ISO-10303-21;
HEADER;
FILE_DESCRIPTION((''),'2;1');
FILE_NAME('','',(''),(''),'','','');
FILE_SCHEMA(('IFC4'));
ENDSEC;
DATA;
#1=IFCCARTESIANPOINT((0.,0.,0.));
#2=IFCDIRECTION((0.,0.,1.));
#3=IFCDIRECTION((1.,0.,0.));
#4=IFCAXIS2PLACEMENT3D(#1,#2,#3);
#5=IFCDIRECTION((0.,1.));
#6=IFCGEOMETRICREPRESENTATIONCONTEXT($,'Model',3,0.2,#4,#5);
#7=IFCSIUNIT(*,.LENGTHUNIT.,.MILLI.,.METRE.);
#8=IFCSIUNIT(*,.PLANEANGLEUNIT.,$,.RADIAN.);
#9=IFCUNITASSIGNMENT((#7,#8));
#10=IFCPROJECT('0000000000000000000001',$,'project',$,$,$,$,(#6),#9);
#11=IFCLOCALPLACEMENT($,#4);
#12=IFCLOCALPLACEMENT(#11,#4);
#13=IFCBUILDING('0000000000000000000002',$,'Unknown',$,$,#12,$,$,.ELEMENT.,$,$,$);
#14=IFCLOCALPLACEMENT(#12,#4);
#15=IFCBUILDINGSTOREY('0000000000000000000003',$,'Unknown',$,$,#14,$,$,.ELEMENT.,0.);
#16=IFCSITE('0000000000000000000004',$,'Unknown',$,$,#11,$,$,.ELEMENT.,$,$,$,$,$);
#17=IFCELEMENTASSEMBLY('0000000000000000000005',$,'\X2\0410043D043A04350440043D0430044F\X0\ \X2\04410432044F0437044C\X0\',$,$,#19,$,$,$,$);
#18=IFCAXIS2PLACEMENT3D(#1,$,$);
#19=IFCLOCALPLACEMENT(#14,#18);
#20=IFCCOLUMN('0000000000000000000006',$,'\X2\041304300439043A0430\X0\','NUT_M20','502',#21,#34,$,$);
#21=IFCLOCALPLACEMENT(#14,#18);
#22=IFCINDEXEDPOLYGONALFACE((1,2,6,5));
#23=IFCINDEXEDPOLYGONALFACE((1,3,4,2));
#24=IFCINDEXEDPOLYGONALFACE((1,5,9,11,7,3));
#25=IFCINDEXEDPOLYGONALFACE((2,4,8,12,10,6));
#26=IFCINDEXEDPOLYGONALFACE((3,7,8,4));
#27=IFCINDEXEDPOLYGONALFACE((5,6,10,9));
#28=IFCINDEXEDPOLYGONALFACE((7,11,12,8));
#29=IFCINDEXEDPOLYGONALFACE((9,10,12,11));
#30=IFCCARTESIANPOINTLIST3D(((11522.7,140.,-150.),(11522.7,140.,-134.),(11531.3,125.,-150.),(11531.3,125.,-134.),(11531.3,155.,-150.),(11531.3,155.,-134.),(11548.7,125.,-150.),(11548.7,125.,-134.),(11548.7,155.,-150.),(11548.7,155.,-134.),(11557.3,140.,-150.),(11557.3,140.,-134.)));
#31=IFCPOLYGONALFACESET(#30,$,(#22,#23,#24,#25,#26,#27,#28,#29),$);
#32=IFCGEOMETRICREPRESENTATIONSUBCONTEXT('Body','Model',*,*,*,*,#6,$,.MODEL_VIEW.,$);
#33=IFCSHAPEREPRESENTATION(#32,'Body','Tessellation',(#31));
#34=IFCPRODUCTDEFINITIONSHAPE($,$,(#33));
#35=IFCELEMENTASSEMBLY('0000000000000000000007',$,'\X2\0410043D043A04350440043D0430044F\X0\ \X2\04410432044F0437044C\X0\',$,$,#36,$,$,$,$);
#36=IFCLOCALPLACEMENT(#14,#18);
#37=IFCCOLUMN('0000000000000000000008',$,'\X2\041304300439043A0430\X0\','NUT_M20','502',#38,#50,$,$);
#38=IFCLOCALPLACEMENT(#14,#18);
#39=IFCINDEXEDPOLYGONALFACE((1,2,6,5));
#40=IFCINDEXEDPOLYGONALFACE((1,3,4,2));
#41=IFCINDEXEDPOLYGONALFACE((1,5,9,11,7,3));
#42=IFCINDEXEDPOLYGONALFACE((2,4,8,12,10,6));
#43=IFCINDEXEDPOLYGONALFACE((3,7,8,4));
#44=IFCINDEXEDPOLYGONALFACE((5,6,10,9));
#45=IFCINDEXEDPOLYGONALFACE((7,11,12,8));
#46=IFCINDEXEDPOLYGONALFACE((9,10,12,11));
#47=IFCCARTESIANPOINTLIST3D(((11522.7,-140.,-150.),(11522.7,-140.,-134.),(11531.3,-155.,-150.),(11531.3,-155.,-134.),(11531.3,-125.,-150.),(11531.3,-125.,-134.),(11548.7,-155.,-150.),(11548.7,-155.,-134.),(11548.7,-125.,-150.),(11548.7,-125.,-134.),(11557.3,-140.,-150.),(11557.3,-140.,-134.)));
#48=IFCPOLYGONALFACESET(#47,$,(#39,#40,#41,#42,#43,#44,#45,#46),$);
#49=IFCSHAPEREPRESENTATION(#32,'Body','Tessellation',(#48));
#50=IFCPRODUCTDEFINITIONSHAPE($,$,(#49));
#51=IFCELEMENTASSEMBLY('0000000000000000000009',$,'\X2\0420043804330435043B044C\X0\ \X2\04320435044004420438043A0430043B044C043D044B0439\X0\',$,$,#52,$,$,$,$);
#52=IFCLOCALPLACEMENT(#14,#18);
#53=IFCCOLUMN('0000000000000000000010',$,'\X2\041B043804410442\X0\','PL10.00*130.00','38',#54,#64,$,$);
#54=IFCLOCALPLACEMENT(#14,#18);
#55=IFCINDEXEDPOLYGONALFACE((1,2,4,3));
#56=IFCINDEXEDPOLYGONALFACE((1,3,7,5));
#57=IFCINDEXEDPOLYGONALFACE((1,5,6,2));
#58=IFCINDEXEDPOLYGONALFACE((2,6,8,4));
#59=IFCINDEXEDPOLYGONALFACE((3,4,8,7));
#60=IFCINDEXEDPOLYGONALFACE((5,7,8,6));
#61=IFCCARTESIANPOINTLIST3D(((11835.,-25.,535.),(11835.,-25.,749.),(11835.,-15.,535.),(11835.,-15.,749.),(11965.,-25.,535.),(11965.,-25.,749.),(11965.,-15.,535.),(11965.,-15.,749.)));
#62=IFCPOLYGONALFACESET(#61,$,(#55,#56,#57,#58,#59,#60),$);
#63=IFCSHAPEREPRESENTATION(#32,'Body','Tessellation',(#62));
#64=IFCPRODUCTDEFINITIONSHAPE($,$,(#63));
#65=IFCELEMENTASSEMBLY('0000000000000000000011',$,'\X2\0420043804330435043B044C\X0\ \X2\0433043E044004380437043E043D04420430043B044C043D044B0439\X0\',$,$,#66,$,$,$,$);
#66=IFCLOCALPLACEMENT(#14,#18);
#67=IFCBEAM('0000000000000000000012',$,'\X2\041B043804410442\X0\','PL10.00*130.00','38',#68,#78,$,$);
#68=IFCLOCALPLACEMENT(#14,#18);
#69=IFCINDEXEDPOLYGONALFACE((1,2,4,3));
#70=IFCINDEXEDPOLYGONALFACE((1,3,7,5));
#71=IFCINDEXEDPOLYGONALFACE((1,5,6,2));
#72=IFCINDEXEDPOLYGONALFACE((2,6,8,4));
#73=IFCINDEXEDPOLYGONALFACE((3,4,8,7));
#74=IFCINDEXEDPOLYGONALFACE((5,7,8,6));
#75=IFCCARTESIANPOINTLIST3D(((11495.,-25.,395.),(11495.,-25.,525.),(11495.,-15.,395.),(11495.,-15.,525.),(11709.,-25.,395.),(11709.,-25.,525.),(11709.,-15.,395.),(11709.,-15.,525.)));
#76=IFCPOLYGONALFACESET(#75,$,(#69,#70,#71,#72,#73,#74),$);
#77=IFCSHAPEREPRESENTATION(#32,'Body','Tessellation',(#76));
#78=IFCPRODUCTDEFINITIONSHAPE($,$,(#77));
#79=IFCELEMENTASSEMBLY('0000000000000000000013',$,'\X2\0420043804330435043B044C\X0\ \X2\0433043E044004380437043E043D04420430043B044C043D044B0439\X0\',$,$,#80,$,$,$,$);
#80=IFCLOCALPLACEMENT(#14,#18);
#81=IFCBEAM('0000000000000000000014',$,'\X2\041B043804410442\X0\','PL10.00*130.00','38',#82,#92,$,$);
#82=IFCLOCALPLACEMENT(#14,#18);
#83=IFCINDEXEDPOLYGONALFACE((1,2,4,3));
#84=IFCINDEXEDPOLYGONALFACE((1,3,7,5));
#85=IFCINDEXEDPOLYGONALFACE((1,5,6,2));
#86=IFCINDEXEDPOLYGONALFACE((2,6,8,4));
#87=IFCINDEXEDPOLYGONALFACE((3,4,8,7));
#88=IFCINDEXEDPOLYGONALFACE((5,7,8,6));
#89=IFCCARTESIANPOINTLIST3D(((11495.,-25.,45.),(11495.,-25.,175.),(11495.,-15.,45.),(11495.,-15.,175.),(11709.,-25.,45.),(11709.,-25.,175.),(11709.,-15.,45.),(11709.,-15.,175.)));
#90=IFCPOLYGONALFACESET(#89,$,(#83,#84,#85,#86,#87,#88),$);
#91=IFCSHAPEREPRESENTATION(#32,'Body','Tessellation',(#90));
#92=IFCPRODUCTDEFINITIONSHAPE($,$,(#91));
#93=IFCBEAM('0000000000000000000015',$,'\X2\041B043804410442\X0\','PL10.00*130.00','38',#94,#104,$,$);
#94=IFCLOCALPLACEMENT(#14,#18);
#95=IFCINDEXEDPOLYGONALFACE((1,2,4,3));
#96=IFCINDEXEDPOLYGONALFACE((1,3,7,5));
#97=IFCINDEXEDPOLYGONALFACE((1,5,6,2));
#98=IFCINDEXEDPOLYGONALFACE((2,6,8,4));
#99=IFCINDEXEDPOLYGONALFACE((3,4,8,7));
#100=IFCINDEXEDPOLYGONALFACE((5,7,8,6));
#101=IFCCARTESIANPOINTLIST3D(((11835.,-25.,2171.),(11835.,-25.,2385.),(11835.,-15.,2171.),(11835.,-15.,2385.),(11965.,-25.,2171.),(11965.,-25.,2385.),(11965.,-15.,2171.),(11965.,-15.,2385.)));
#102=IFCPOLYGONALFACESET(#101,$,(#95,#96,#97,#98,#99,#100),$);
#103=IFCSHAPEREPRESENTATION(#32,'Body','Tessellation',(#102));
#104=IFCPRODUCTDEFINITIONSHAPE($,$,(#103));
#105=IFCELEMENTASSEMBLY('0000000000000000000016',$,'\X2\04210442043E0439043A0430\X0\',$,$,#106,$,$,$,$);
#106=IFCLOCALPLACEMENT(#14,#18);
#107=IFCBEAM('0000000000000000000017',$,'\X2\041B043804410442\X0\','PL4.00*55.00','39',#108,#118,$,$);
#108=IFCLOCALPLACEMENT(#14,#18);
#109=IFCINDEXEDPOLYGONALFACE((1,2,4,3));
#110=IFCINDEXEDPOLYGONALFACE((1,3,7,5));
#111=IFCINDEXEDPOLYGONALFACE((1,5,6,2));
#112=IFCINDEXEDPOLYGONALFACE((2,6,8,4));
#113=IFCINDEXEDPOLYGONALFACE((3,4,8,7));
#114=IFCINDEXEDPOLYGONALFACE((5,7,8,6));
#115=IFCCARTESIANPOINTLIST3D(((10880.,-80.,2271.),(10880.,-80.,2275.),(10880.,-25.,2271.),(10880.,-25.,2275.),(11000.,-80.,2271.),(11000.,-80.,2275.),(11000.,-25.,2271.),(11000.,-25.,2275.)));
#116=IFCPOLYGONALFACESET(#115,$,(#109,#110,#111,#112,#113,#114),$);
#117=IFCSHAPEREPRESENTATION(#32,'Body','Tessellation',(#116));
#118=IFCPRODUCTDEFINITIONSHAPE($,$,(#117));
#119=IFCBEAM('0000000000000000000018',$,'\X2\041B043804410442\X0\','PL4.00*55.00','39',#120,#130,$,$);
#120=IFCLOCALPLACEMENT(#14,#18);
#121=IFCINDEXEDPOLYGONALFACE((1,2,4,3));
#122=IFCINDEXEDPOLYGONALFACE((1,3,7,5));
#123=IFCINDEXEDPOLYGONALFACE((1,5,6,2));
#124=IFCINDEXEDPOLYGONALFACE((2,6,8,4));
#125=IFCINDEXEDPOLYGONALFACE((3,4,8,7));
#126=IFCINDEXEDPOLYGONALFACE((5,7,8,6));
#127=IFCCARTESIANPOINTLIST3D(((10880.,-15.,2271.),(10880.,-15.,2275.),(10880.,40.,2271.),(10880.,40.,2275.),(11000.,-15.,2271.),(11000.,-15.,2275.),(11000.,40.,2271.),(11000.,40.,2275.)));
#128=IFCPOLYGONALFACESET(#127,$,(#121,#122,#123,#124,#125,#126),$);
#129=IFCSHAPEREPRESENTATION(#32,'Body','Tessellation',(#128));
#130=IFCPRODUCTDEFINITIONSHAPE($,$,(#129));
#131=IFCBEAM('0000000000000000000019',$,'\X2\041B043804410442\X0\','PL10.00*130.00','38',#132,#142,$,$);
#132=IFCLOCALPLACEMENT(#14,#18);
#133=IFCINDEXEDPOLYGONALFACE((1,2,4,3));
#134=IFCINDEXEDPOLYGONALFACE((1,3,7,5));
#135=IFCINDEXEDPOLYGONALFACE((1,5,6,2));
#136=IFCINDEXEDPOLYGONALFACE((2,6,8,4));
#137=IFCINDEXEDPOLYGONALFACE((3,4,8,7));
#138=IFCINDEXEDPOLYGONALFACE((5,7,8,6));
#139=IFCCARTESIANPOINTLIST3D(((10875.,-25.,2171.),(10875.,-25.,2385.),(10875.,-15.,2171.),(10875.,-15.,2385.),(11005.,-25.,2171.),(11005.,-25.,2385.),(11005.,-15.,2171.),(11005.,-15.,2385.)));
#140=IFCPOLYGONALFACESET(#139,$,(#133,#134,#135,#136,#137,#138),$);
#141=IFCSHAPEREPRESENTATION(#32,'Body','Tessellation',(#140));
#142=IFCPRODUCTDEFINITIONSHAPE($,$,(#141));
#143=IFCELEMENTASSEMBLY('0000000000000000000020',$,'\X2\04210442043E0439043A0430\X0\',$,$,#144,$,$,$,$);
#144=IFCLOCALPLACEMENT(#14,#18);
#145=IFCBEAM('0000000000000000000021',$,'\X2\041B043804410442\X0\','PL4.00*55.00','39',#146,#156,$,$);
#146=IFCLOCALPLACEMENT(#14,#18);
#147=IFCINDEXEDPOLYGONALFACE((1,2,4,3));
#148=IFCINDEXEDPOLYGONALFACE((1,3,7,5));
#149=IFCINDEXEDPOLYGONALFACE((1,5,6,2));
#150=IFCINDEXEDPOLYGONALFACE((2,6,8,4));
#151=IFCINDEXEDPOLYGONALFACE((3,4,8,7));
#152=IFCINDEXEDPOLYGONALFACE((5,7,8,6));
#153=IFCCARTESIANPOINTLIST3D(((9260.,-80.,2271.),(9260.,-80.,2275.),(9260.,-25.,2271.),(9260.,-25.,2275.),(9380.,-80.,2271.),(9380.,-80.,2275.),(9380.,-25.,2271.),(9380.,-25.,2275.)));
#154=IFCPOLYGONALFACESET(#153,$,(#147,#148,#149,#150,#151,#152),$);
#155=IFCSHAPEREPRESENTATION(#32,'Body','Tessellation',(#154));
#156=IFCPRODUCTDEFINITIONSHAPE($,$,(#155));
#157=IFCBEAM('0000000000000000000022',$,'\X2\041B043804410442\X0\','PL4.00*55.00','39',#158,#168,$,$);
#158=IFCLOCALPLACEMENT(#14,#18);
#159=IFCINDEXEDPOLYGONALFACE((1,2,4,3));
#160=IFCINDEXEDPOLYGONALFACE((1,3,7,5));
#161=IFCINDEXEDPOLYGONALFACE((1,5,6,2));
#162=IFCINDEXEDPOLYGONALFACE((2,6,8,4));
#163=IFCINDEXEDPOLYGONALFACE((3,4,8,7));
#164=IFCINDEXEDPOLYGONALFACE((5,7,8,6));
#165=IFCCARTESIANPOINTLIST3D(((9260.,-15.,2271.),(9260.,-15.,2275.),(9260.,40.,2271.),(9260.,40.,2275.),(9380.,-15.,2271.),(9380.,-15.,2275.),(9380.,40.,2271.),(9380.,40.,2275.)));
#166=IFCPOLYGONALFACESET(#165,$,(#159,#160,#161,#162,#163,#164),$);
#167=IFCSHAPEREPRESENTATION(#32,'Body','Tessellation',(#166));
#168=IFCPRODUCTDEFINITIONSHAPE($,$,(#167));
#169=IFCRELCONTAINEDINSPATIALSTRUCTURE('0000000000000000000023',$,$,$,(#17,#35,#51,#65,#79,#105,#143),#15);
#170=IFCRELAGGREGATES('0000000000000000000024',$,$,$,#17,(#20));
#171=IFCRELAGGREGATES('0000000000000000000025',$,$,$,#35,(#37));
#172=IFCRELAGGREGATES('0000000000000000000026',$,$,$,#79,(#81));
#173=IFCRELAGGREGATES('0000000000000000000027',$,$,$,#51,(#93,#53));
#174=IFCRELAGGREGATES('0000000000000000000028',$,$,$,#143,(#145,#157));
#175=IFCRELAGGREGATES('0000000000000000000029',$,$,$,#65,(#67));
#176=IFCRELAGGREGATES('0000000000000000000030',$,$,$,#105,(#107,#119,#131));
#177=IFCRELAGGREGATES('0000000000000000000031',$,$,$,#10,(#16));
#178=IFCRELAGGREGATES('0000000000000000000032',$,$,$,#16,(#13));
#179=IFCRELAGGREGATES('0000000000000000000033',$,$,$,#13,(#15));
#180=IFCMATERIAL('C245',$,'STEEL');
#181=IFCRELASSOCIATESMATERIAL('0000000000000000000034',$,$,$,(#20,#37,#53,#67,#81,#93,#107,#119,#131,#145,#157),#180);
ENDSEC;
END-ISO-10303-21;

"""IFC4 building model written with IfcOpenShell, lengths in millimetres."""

from ifc_helpers import new_model, si_unit, direction, frame, origin_with_axes, place, context, subcontext, project, spatial, line, indexed_curve, outline, extrude, material, element, aggregate, save


model = new_model("IFC4")

# Units and contexts
model_context = context("Model", 3, precision=0.2, world=origin_with_axes(), true_north=direction((0.0, 1.0)))
body_context = subcontext(model_context, "Body", "Model", "MODEL_VIEW")
ifc_project = project(units=[si_unit("LENGTHUNIT", "METRE", prefix="MILLI"), si_unit("PLANEANGLEUNIT", "RADIAN")], contexts=[model_context])

# Site, building, storey
site_placement = place(None, origin_with_axes())
site = spatial("IfcSite", under=ifc_project, at=site_placement, Name="Unknown", CompositionType="ELEMENT")
building_placement = place(site_placement, origin_with_axes())
building = spatial("IfcBuilding", under=site, at=building_placement, Name="Unknown", CompositionType="ELEMENT")
storey_placement = place(building_placement, origin_with_axes())
storey = spatial("IfcBuildingStorey", under=building, at=storey_placement, Name="Unknown", CompositionType="ELEMENT", Elevation=0.0)

# Element assemblies, columns
assembly_1_placement = place(storey_placement, frame((11540.0, 140.0, -125.0), z_axis=(-1.0, 0.0, 0.0), x_axis=(0.0, 0.0, -1.0)))
assembly_1 = element("IfcElementAssembly", 1, at=assembly_1_placement, inside=storey, Name="Анкерная связь")
ifc_material_1 = material(Name="C245", Category="STEEL")
column_1_placement = place(assembly_1_placement, frame((9.0, 0.0, 0.0), z_axis=(0.0, 0.0, -1.0), x_axis=(1.0, 0.0, 0.0)))
column_1 = element("IfcColumn", 2, at=column_1_placement, material=ifc_material_1, Name="Гайка", Description="NUT_M20", ObjectType="502", context=body_context, shape_type="SolidModel", body=[
    extrude(outline(indexed_curve([(8.7, -15.0), (17.3, 0.0), (8.7, 15.0), (-8.7, 15.0), (-17.3, 0.0), (-8.7, -15.0)], segments=[line(1, 2, 3, 4, 5, 6, 1)])), frame((0.0, 0.0, 0.0), z_axis=(-1.0, 0.0, 0.0), x_axis=(0.0, 0.0, 1.0)), (0.0, 0.0, -1.0), 16.0),
])
assembly_2_placement = place(storey_placement, frame((11540.0, -140.0, -125.0), z_axis=(1.0, 0.0, 0.0), x_axis=(0.0, 0.0, -1.0)))
assembly_2 = element("IfcElementAssembly", 3, at=assembly_2_placement, inside=storey, Name="Анкерная связь")
column_2_placement = place(assembly_2_placement, frame((9.0, 0.0, 0.0), z_axis=(0.0, 0.0, 1.0), x_axis=(1.0, 0.0, 0.0)))
column_2 = element("IfcColumn", 4, at=column_2_placement, material=ifc_material_1, Name="Гайка", Description="NUT_M20", ObjectType="502", context=body_context, shape_type="SolidModel", body=[
    extrude(outline(indexed_curve([(8.7, -15.0), (17.3, 0.0), (8.7, 15.0), (-8.7, 15.0), (-17.3, 0.0), (-8.7, -15.0)], segments=[line(1, 2, 3, 4, 5, 6, 1)])), frame((0.0, 0.0, 0.0), z_axis=(-1.0, 0.0, 0.0), x_axis=(0.0, 0.0, 1.0)), (0.0, 0.0, -1.0), 16.0),
])
assembly_3_placement = place(storey_placement, frame((11900.0, -20.0, 2400.0), z_axis=(0.0, -1.0, 0.0), x_axis=(0.0, 0.0, -1.0)))
assembly_3 = element("IfcElementAssembly", 5, at=assembly_3_placement, inside=storey, Name="Ригель вертикальный")
column_3_placement = place(assembly_3_placement, frame((1865.0, 0.0, 0.0), z_axis=(0.0, 0.0, 1.0), x_axis=(-1.0, 0.0, 0.0)))
column_3 = element("IfcColumn", 6, at=column_3_placement, material=ifc_material_1, Name="Лист", Description="PL10.00*130.00", ObjectType="38", context=body_context, shape_type="SolidModel", body=[
    extrude(outline(indexed_curve([(-5.0, -65.0), (5.0, -65.0), (5.0, 65.0), (-5.0, 65.0)], segments=[line(1, 2, 3, 4, 1)])), frame((0.0, 0.0, 0.0), z_axis=(-1.0, 0.0, 0.0), x_axis=(0.0, 0.0, 1.0)), (0.0, 0.0, -1.0), 214.0),
])

aggregate(assembly_1, [column_1])

aggregate(assembly_2, [column_2])

# Element assemblies, beams
assembly_4_placement = place(storey_placement, frame((11400.0, -20.0, 460.0), z_axis=(0.0, -1.0, 0.0), x_axis=(1.0, 0.0, 0.0)))
assembly_4 = element("IfcElementAssembly", 7, at=assembly_4_placement, inside=storey, Name="Ригель горизонтальный")
beam_1_placement = place(assembly_4_placement, frame((95.0, 0.0, 0.0), z_axis=(0.0, 0.0, 1.0), x_axis=(1.0, 0.0, 0.0)))
beam_1 = element("IfcBeam", 8, at=beam_1_placement, material=ifc_material_1, Name="Лист", Description="PL10.00*130.00", ObjectType="38", context=body_context, shape_type="SolidModel", body=[
    extrude(outline(indexed_curve([(-5.0, -65.0), (5.0, -65.0), (5.0, 65.0), (-5.0, 65.0)], segments=[line(1, 2, 3, 4, 1)])), frame((0.0, 0.0, 0.0), z_axis=(-1.0, 0.0, 0.0), x_axis=(0.0, 0.0, 1.0)), (0.0, 0.0, -1.0), 214.0),
])
assembly_5_placement = place(storey_placement, frame((11400.0, -20.0, 110.0), z_axis=(0.0, -1.0, 0.0), x_axis=(1.0, 0.0, 0.0)))
assembly_5 = element("IfcElementAssembly", 9, at=assembly_5_placement, inside=storey, Name="Ригель горизонтальный")
beam_2_placement = place(assembly_5_placement, frame((95.0, 0.0, 0.0), z_axis=(0.0, 0.0, 1.0), x_axis=(1.0, 0.0, 0.0)))
beam_2 = element("IfcBeam", 10, at=beam_2_placement, material=ifc_material_1, Name="Лист", Description="PL10.00*130.00", ObjectType="38", context=body_context, shape_type="SolidModel", body=[
    extrude(outline(indexed_curve([(-5.0, -65.0), (5.0, -65.0), (5.0, 65.0), (-5.0, 65.0)], segments=[line(1, 2, 3, 4, 1)])), frame((0.0, 0.0, 0.0), z_axis=(-1.0, 0.0, 0.0), x_axis=(0.0, 0.0, 1.0)), (0.0, 0.0, -1.0), 214.0),
])
aggregate(assembly_5, [beam_2])

# Beam
beam_3_placement = place(assembly_3_placement, frame((15.0, 0.0, 0.0), z_axis=(0.0, 0.0, 1.0), x_axis=(1.0, 0.0, 0.0)))
beam_3 = element("IfcBeam", 11, at=beam_3_placement, material=ifc_material_1, Name="Лист", Description="PL10.00*130.00", ObjectType="38", context=body_context, shape_type="SolidModel", body=[
    extrude(outline(indexed_curve([(-5.0, -65.0), (5.0, -65.0), (5.0, 65.0), (-5.0, 65.0)], segments=[line(1, 2, 3, 4, 1)])), frame((0.0, 0.0, 0.0), z_axis=(-1.0, 0.0, 0.0), x_axis=(0.0, 0.0, 1.0)), (0.0, 0.0, -1.0), 214.0),
])
aggregate(assembly_3, [beam_3, column_3])

# Element assemblies, beams
assembly_6_placement = place(storey_placement, frame((10940.0, -20.0, 0.0), z_axis=(-1.0, 0.0, 0.0), x_axis=(0.0, 0.0, 1.0)))
assembly_6 = element("IfcElementAssembly", 12, at=assembly_6_placement, inside=storey, Name="Стойка")
beam_4_placement = place(assembly_6_placement, frame((2273.0, -32.5, -60.0), z_axis=(-1.0, 0.0, 0.0), x_axis=(0.0, 0.0, 1.0)))
beam_4 = element("IfcBeam", 13, at=beam_4_placement, material=ifc_material_1, Name="Лист", Description="PL4.00*55.00", ObjectType="39", context=body_context, shape_type="SolidModel", body=[
    extrude(outline(indexed_curve([(-2.0, -27.5), (2.0, -27.5), (2.0, 27.5), (-2.0, 27.5)], segments=[line(1, 2, 3, 4, 1)])), frame((0.0, 0.0, 0.0), z_axis=(-1.0, 0.0, 0.0), x_axis=(0.0, 0.0, 1.0)), (0.0, 0.0, -1.0), 120.0),
])
beam_5_placement = place(assembly_6_placement, frame((2273.0, 32.5, -60.0), z_axis=(1.0, 0.0, 0.0), x_axis=(0.0, 0.0, 1.0)))
beam_5 = element("IfcBeam", 14, at=beam_5_placement, material=ifc_material_1, Name="Лист", Description="PL4.00*55.00", ObjectType="39", context=body_context, shape_type="SolidModel", body=[
    extrude(outline(indexed_curve([(-2.0, -27.5), (2.0, -27.5), (2.0, 27.5), (-2.0, 27.5)], segments=[line(1, 2, 3, 4, 1)])), frame((0.0, 0.0, 0.0), z_axis=(-1.0, 0.0, 0.0), x_axis=(0.0, 0.0, 1.0)), (0.0, 0.0, -1.0), 120.0),
])
beam_6_placement = place(assembly_6_placement, frame((2385.0, 0.0, 0.0), z_axis=(0.0, -1.0, 0.0), x_axis=(-1.0, 0.0, 0.0)))
beam_6 = element("IfcBeam", 15, at=beam_6_placement, material=ifc_material_1, Name="Лист", Description="PL10.00*130.00", ObjectType="38", context=body_context, shape_type="SolidModel", body=[
    extrude(outline(indexed_curve([(-5.0, -65.0), (5.0, -65.0), (5.0, 65.0), (-5.0, 65.0)], segments=[line(1, 2, 3, 4, 1)])), frame((0.0, 0.0, 0.0), z_axis=(-1.0, 0.0, 0.0), x_axis=(0.0, 0.0, 1.0)), (0.0, 0.0, -1.0), 214.0),
])
assembly_7_placement = place(storey_placement, frame((9320.0, -20.0, 0.0), z_axis=(-1.0, 0.0, 0.0), x_axis=(0.0, 0.0, 1.0)))
assembly_7 = element("IfcElementAssembly", 16, at=assembly_7_placement, inside=storey, Name="Стойка")
beam_7_placement = place(assembly_7_placement, frame((2273.0, -32.5, -60.0), z_axis=(-1.0, 0.0, 0.0), x_axis=(0.0, 0.0, 1.0)))
beam_7 = element("IfcBeam", 17, at=beam_7_placement, material=ifc_material_1, Name="Лист", Description="PL4.00*55.00", ObjectType="39", context=body_context, shape_type="SolidModel", body=[
    extrude(outline(indexed_curve([(-2.0, -27.5), (2.0, -27.5), (2.0, 27.5), (-2.0, 27.5)], segments=[line(1, 2, 3, 4, 1)])), frame((0.0, 0.0, 0.0), z_axis=(-1.0, 0.0, 0.0), x_axis=(0.0, 0.0, 1.0)), (0.0, 0.0, -1.0), 120.0),
])
beam_8_placement = place(assembly_7_placement, frame((2273.0, 32.5, -60.0), z_axis=(1.0, 0.0, 0.0), x_axis=(0.0, 0.0, 1.0)))
beam_8 = element("IfcBeam", 18, at=beam_8_placement, material=ifc_material_1, Name="Лист", Description="PL4.00*55.00", ObjectType="39", context=body_context, shape_type="SolidModel", body=[
    extrude(outline(indexed_curve([(-2.0, -27.5), (2.0, -27.5), (2.0, 27.5), (-2.0, 27.5)], segments=[line(1, 2, 3, 4, 1)])), frame((0.0, 0.0, 0.0), z_axis=(-1.0, 0.0, 0.0), x_axis=(0.0, 0.0, 1.0)), (0.0, 0.0, -1.0), 120.0),
])
aggregate(assembly_7, [beam_7, beam_8])

aggregate(assembly_4, [beam_1])

aggregate(assembly_6, [beam_4, beam_5, beam_6])

save(model, "model.ifc")
